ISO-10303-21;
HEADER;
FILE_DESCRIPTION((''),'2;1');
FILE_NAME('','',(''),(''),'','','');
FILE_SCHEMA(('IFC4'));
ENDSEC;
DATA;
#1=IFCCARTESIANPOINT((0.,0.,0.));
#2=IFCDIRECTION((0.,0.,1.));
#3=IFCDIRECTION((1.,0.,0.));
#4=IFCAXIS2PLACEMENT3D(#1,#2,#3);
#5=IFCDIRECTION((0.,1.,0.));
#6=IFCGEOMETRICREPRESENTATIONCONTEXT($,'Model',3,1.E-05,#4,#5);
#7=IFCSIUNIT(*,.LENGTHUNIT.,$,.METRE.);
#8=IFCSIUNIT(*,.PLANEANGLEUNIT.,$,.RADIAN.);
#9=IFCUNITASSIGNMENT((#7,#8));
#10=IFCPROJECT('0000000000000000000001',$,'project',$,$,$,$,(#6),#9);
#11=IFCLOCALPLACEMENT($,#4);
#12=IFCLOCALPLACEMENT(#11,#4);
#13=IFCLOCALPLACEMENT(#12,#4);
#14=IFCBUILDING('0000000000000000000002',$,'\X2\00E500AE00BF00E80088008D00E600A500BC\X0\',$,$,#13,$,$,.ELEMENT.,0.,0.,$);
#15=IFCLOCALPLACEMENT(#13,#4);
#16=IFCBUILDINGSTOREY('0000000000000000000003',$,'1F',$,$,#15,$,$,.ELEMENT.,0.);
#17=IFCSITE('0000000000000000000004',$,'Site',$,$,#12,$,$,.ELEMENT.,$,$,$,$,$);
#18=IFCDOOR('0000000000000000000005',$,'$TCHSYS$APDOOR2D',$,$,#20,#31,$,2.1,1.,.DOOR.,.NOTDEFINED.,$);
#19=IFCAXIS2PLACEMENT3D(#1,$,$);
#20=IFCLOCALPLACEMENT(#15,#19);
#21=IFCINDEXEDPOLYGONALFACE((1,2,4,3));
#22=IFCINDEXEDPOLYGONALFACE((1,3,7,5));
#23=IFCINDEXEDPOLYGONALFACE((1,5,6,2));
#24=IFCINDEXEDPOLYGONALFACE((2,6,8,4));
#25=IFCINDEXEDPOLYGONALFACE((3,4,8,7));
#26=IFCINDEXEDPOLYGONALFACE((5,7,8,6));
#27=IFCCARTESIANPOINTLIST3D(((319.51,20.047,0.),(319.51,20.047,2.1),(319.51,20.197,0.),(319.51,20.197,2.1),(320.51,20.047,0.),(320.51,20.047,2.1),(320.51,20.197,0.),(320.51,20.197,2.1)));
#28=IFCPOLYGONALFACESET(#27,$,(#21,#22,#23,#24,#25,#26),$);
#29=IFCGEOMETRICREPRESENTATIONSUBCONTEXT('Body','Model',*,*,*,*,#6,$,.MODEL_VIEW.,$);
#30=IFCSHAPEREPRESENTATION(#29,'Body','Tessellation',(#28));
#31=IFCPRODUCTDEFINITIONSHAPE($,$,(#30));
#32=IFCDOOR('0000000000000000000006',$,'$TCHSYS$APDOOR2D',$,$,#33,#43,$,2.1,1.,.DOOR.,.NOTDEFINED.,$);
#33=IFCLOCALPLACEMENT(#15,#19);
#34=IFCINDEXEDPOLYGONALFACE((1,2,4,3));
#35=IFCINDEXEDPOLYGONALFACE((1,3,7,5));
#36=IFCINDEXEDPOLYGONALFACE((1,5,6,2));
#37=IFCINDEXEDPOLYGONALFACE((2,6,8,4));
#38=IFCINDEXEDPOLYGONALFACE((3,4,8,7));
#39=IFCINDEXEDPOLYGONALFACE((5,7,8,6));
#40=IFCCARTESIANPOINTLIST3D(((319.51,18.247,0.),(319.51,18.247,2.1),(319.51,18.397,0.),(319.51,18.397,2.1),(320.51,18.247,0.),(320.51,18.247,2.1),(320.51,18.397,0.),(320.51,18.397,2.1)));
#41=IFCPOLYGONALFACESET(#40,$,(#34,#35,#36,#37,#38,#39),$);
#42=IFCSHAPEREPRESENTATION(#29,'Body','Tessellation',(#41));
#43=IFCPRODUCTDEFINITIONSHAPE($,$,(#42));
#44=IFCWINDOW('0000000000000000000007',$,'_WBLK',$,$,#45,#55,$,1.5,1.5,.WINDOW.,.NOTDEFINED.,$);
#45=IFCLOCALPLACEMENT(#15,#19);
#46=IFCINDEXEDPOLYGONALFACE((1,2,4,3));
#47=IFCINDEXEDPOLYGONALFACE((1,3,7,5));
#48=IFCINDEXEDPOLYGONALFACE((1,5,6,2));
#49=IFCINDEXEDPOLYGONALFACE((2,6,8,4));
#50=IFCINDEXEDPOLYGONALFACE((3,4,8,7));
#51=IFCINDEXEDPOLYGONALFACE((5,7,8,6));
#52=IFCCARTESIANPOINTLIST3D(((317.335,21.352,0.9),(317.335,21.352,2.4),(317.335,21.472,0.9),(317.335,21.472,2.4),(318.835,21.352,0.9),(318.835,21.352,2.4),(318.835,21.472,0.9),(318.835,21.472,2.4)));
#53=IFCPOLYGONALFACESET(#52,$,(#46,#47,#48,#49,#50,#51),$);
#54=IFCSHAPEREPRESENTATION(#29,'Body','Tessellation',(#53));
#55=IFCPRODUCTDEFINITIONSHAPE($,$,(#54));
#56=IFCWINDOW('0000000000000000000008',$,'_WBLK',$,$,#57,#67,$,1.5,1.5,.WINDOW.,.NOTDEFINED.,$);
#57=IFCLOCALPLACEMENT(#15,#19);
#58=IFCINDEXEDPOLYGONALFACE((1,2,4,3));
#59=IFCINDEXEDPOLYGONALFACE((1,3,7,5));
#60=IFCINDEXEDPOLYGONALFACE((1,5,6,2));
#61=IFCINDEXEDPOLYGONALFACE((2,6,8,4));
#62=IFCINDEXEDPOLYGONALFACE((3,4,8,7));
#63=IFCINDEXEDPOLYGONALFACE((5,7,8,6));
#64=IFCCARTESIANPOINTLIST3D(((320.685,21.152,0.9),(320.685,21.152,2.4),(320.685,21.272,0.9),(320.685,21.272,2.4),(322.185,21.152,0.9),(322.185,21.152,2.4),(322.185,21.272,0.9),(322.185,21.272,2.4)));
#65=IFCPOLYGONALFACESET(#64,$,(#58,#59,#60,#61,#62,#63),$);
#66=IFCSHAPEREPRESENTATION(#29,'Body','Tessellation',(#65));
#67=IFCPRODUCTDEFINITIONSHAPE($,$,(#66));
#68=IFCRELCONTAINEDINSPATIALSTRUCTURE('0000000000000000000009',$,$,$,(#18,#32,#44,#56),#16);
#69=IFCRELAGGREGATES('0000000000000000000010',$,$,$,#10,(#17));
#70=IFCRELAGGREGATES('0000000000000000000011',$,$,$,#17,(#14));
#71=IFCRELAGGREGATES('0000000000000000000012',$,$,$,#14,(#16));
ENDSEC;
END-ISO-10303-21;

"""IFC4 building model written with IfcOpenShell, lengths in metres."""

from ifc_helpers import new_model, si_unit, direction, frame, frame_2d, origin_with_axes, place, context, subcontext, project, spatial, rectangle, extrude, element, save


model = new_model("IFC4")

# Units and contexts
model_context = context("Model", 3, precision=1e-05, world=origin_with_axes(), true_north=direction((0.0, 1.0, 0.0)))
body_context = subcontext(model_context, "Body", "Model", "MODEL_VIEW")
ifc_project = project(units=[si_unit("LENGTHUNIT", "METRE"), si_unit("PLANEANGLEUNIT", "RADIAN")], contexts=[model_context])

# Site, building, storey
placement = place(None, origin_with_axes())
site_placement = place(placement, origin_with_axes())
site = spatial("IfcSite", under=ifc_project, at=site_placement, Name="Site", CompositionType="ELEMENT")
building_placement = place(site_placement, origin_with_axes())
building = spatial("IfcBuilding", under=site, at=building_placement, Name="å®¿è\u0088\u008dæ¥¼", CompositionType="ELEMENT", ElevationOfRefHeight=0.0, ElevationOfTerrain=0.0)
storey_placement = place(building_placement, origin_with_axes())
storey = spatial("IfcBuildingStorey", under=building, at=storey_placement, Name="1F", CompositionType="ELEMENT", Elevation=0.0)

# Doors
for number, where, z_axis, x_axis, name in (
    (1, (320.01, 20.122, 0.0), (0.0, 0.0, 1.0), (1.0, 0.0, 0.0), "$TCHSYS$APDOOR2D"),
    (2, (320.01, 18.322, 0.0), (0.0, 0.0, 1.0), (1.0, 0.0, 0.0), "$TCHSYS$APDOOR2D"),
):
    element("IfcDoor", number, at=place(storey_placement, frame(where, z_axis=z_axis, x_axis=x_axis)), inside=storey, Name=name, OperationType="NOTDEFINED", OverallHeight=2.1, OverallWidth=1.0, PredefinedType="DOOR", context=body_context, shape_type="SweptSolid", body=[
        extrude(rectangle(XDim=1.0, YDim=0.15, at=frame_2d((0.0, 0.0), x_axis=(1.0, 0.0, 0.0))), frame((0.0, 0.0, 0.0), z_axis=(0.0, 0.0, 1.0)), (0.0, 0.0, 1.0), 2.1),
    ])

# Windows
for number, where, z_axis, x_axis, name in (
    (3, (318.085, 21.412, 0.9), (0.0, 0.0, 1.0), (1.0, 0.0, 0.0), "_WBLK"),
    (4, (321.435, 21.212, 0.9), (0.0, 0.0, 1.0), (1.0, 0.0, 0.0), "_WBLK"),
):
    element("IfcWindow", number, at=place(storey_placement, frame(where, z_axis=z_axis, x_axis=x_axis)), inside=storey, Name=name, OverallHeight=1.5, OverallWidth=1.5, PartitioningType="NOTDEFINED", PredefinedType="WINDOW", context=body_context, shape_type="SweptSolid", body=[
        extrude(rectangle(XDim=1.5, YDim=0.12, at=frame_2d((0.0, 0.0), x_axis=(1.0, 0.0, 0.0))), frame((0.0, 0.0, 0.0), z_axis=(0.0, 0.0, 1.0)), (0.0, 0.0, 1.0), 1.5),
    ])

save(model, "model.ifc")
